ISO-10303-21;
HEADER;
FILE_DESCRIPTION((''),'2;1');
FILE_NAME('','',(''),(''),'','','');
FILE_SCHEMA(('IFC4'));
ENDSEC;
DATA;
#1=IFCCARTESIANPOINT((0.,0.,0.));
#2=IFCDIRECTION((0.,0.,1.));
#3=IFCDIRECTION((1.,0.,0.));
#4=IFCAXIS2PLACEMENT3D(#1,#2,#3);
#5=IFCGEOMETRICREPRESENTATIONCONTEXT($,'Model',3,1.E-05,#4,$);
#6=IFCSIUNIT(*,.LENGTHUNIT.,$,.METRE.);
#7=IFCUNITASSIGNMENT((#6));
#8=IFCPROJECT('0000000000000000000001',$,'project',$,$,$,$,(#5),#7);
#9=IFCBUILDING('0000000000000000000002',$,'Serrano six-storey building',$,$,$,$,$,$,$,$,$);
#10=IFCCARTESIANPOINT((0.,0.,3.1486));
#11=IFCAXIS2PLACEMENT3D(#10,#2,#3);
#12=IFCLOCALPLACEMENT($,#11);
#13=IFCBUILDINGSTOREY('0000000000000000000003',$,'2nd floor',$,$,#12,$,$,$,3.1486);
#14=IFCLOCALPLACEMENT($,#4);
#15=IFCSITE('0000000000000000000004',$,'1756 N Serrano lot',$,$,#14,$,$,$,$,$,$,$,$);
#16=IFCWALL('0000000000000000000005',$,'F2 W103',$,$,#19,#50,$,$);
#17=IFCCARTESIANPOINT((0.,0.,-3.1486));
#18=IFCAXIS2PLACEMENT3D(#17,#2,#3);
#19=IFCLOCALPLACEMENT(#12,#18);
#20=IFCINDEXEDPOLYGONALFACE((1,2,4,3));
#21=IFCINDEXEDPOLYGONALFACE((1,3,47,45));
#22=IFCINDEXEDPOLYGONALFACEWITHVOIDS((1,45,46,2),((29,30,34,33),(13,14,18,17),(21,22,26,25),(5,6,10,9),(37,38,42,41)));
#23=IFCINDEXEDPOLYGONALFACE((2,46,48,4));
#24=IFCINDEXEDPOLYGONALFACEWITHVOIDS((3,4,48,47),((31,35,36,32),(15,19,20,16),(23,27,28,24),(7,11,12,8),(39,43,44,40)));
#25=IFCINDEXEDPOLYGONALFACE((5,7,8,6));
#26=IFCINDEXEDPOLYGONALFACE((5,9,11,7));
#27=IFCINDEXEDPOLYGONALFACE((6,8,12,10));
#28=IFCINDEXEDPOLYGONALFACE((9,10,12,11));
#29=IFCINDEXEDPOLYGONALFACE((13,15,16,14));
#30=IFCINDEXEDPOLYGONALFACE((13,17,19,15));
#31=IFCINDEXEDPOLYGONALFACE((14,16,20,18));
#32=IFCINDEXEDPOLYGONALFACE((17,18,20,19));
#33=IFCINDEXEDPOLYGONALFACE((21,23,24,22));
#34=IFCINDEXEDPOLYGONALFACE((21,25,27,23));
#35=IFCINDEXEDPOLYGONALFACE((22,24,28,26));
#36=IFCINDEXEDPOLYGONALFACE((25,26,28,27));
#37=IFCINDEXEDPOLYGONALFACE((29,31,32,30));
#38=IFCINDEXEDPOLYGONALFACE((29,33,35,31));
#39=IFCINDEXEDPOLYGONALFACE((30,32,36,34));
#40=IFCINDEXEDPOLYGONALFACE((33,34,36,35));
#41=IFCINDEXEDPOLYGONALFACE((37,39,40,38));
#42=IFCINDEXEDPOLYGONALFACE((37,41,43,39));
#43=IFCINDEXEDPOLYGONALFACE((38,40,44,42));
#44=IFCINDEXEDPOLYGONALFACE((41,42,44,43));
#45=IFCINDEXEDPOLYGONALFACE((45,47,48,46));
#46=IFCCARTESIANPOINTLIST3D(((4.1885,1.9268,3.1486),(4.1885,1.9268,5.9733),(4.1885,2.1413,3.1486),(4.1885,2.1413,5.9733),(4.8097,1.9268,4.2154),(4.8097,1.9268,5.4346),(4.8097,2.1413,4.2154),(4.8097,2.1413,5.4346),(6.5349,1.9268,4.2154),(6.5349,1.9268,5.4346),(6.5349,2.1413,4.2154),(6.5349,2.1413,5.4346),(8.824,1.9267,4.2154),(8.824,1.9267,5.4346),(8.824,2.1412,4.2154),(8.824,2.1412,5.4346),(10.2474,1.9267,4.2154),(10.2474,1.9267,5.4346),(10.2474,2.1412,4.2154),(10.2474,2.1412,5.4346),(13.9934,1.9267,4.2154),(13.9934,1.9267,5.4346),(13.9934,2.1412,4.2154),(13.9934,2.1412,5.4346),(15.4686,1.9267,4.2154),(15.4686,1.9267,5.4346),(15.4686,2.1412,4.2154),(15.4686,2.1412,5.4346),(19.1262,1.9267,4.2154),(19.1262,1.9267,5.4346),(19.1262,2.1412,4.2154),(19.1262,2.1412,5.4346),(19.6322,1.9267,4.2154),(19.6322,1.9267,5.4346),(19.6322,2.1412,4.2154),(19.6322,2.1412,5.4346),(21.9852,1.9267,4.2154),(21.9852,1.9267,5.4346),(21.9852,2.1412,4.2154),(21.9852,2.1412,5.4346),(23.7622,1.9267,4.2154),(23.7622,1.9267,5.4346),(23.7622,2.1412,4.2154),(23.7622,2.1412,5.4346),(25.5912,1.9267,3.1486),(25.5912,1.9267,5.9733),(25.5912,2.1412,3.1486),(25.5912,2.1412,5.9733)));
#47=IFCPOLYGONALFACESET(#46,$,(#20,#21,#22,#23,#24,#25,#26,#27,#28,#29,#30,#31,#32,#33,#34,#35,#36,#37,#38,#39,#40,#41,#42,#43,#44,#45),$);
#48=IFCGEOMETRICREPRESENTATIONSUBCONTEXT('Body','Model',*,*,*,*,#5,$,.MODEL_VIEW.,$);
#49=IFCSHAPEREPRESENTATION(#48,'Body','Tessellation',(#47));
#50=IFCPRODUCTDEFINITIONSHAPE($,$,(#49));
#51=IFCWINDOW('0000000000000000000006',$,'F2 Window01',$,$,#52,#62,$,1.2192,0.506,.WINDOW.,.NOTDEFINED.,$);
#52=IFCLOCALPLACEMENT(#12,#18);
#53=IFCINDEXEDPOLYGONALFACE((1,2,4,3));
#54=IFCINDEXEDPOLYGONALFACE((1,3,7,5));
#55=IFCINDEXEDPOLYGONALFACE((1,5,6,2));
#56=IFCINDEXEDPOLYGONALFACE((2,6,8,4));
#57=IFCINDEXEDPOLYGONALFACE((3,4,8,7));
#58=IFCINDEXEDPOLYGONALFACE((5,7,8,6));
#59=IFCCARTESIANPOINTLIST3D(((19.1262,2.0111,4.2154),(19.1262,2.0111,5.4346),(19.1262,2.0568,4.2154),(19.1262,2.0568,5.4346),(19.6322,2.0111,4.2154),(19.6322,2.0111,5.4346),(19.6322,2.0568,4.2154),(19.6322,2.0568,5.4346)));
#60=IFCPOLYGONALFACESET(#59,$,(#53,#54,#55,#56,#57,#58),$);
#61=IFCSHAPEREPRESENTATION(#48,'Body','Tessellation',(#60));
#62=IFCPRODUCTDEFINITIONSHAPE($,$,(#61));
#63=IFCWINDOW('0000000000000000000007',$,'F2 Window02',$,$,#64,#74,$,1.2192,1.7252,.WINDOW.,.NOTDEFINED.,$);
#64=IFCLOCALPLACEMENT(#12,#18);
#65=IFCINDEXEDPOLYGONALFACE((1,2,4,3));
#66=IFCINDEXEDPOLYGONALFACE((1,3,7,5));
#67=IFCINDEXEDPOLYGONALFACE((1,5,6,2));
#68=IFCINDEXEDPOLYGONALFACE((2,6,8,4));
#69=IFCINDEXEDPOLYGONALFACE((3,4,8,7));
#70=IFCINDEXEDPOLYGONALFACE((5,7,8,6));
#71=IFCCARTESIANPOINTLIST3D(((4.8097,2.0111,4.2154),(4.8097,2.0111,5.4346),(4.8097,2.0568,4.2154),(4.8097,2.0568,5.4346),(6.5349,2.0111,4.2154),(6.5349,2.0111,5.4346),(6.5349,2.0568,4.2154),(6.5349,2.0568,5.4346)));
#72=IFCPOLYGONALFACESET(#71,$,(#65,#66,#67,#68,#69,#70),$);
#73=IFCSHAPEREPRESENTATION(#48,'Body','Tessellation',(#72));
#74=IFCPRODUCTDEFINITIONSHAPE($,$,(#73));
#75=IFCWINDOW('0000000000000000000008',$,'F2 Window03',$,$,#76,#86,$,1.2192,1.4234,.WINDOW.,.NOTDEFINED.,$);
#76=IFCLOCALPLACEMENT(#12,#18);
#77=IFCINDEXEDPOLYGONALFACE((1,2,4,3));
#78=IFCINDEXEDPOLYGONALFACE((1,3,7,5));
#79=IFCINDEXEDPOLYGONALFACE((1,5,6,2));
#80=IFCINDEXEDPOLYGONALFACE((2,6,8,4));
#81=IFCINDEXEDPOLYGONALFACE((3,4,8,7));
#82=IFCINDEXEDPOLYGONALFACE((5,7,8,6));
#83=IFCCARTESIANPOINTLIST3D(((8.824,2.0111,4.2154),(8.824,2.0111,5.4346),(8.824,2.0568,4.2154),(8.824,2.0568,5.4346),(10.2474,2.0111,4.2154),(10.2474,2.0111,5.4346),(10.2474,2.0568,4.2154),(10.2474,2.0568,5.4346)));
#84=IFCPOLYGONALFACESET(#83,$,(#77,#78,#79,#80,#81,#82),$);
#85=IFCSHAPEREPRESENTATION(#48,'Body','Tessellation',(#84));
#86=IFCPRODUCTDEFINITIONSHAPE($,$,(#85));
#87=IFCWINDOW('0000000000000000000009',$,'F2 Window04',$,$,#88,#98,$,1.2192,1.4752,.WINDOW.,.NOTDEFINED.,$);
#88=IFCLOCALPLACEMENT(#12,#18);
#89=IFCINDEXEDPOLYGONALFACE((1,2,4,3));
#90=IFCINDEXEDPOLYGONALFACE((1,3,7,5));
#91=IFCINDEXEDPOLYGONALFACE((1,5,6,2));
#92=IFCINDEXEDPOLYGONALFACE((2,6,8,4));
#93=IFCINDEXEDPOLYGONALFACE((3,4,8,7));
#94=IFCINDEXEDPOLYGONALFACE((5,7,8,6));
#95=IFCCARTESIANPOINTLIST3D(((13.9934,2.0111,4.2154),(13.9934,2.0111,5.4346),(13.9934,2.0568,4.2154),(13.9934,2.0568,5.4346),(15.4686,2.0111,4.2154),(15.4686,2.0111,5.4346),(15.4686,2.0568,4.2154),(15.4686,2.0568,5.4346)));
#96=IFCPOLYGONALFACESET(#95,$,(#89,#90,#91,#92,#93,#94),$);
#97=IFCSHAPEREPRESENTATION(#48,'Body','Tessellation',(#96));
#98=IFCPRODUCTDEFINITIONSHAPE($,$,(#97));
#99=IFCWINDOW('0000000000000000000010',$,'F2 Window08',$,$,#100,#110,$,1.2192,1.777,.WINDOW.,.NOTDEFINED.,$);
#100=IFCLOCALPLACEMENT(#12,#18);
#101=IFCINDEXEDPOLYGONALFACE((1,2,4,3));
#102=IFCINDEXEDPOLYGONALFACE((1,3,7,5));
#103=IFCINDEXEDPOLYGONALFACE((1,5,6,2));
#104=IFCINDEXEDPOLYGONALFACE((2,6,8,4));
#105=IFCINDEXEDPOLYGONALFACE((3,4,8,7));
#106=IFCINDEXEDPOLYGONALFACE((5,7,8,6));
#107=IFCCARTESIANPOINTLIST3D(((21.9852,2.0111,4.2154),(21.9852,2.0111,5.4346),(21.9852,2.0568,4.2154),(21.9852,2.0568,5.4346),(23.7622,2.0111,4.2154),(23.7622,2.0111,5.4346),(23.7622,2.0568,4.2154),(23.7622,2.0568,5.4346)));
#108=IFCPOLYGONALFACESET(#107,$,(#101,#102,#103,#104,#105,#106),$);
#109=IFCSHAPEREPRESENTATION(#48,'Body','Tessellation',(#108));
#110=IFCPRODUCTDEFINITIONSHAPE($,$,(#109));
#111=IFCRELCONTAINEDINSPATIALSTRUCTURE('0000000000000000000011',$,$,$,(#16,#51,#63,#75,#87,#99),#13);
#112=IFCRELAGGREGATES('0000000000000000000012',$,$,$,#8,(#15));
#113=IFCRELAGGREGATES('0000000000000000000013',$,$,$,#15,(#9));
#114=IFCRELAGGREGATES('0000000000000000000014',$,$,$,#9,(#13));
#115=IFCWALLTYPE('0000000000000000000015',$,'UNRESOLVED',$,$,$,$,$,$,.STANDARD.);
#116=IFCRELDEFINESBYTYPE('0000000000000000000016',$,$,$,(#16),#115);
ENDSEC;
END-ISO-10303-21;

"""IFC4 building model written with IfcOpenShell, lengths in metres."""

from ifc_helpers import new_model, si_unit, frame, origin_with_axes, place, context, subcontext, project, spatial, polyline, outline, extrude, type_object, element, fill, save


model = new_model("IFC4")

# Units and contexts
model_context = context("Model", 3, precision=1e-05, world=origin_with_axes())
body_context = subcontext(model_context, "Body", "Model", "MODEL_VIEW")
ifc_project = project(units=[si_unit("LENGTHUNIT", "METRE")], contexts=[model_context])

# Site, building, storey
site_placement = place(None, origin_with_axes())
site = spatial("IfcSite", under=ifc_project, at=site_placement, Name="1756 N Serrano lot")
building = spatial("IfcBuilding", under=site, Name="Serrano six-storey building")
storey_placement = place(None, frame((0.0, 0.0, 3.1486), z_axis=(0.0, 0.0, 1.0), x_axis=(1.0, 0.0, 0.0)))
storey = spatial("IfcBuildingStorey", under=building, at=storey_placement, Name="2nd floor", Elevation=3.1486)

# Wall, openings, windows
wall_type = type_object("IfcWallType", Name="UNRESOLVED", PredefinedType="STANDARD")
wall_1_placement = place(storey_placement, frame((0.0, 0.0, -3.1486), z_axis=(0.0, 0.0, 1.0), x_axis=(1.0, 0.0, 0.0)))
wall_1 = element("IfcWall", 1, at=wall_1_placement, inside=storey, type_object=wall_type, Name="F2 W103", context=body_context, shape_type="SweptSolid", body=[
    extrude(outline(polyline([(4.1885, 1.9268), (4.1885, 2.1413), (25.5912, 2.1412), (25.5912, 1.9267), (4.1885, 1.9268)])), frame((0.0, 0.0, 3.1486)), (0.0, 0.0, 1.0), 2.8247),
])
opening_1_placement = place(None, origin_with_axes())
opening_1 = element("IfcOpeningElement", 2, at=opening_1_placement, cuts=wall_1, PredefinedType="OPENING", context=body_context, shape_type="SweptSolid", body=[
    extrude(outline(polyline([(19.6322, 2.1595), (19.6322, 1.9084), (19.1262, 1.9084), (19.1262, 2.1595), (19.6322, 2.1595)])), frame((0.0, 0.0, 4.2154)), (0.0, 0.0, 1.0), 1.2192),
])
opening_2_placement = place(None, origin_with_axes())
opening_2 = element("IfcOpeningElement", 3, at=opening_2_placement, cuts=wall_1, PredefinedType="OPENING", context=body_context, shape_type="SweptSolid", body=[
    extrude(outline(polyline([(6.5349, 2.1595), (6.5349, 1.9084), (4.8097, 1.9084), (4.8097, 2.1595), (6.5349, 2.1595)])), frame((0.0, 0.0, 4.2154)), (0.0, 0.0, 1.0), 1.2192),
])
opening_3_placement = place(None, origin_with_axes())
opening_3 = element("IfcOpeningElement", 4, at=opening_3_placement, cuts=wall_1, PredefinedType="OPENING", context=body_context, shape_type="SweptSolid", body=[
    extrude(outline(polyline([(10.2474, 2.1595), (10.2474, 1.9084), (8.824, 1.9084), (8.824, 2.1595), (10.2474, 2.1595)])), frame((0.0, 0.0, 4.2154)), (0.0, 0.0, 1.0), 1.2192),
])
opening_4_placement = place(None, origin_with_axes())
opening_4 = element("IfcOpeningElement", 5, at=opening_4_placement, cuts=wall_1, PredefinedType="OPENING", context=body_context, shape_type="SweptSolid", body=[
    extrude(outline(polyline([(15.4686, 2.1595), (15.4686, 1.9084), (13.9934, 1.9084), (13.9934, 2.1595), (15.4686, 2.1595)])), frame((0.0, 0.0, 4.2154)), (0.0, 0.0, 1.0), 1.2192),
])
opening_5_placement = place(None, origin_with_axes())
opening_5 = element("IfcOpeningElement", 6, at=opening_5_placement, cuts=wall_1, PredefinedType="OPENING", context=body_context, shape_type="SweptSolid", body=[
    extrude(outline(polyline([(23.7622, 2.1595), (23.7622, 1.9084), (21.9852, 1.9084), (21.9852, 2.1595), (23.7622, 2.1595)])), frame((0.0, 0.0, 4.2154)), (0.0, 0.0, 1.0), 1.2192),
])
window_1_placement = place(storey_placement, frame((0.0, 0.0, -3.1486), z_axis=(0.0, 0.0, 1.0), x_axis=(1.0, 0.0, 0.0)))
window_1 = element("IfcWindow", 7, at=window_1_placement, inside=storey, Name="F2 Window01", OverallHeight=1.2192, OverallWidth=0.506, PartitioningType="NOTDEFINED", PredefinedType="WINDOW", context=body_context, shape_type="SweptSolid", body=[
    extrude(outline(polyline([(19.6322, 2.0568), (19.6322, 2.0111), (19.1262, 2.0111), (19.1262, 2.0568), (19.6322, 2.0568)])), frame((0.0, 0.0, 4.2154)), (0.0, 0.0, 1.0), 1.2192),
])
fill(opening_1, window_1)
window_2_placement = place(storey_placement, frame((0.0, 0.0, -3.1486), z_axis=(0.0, 0.0, 1.0), x_axis=(1.0, 0.0, 0.0)))
window_2 = element("IfcWindow", 8, at=window_2_placement, inside=storey, Name="F2 Window02", OverallHeight=1.2192, OverallWidth=1.7252, PartitioningType="NOTDEFINED", PredefinedType="WINDOW", context=body_context, shape_type="SweptSolid", body=[
    extrude(outline(polyline([(6.5349, 2.0568), (6.5349, 2.0111), (4.8097, 2.0111), (4.8097, 2.0568), (6.5349, 2.0568)])), frame((0.0, 0.0, 4.2154)), (0.0, 0.0, 1.0), 1.2192),
])
fill(opening_2, window_2)
window_3_placement = place(storey_placement, frame((0.0, 0.0, -3.1486), z_axis=(0.0, 0.0, 1.0), x_axis=(1.0, 0.0, 0.0)))
window_3 = element("IfcWindow", 9, at=window_3_placement, inside=storey, Name="F2 Window03", OverallHeight=1.2192, OverallWidth=1.4234, PartitioningType="NOTDEFINED", PredefinedType="WINDOW", context=body_context, shape_type="SweptSolid", body=[
    extrude(outline(polyline([(10.2474, 2.0568), (10.2474, 2.0111), (8.824, 2.0111), (8.824, 2.0568), (10.2474, 2.0568)])), frame((0.0, 0.0, 4.2154)), (0.0, 0.0, 1.0), 1.2192),
])
fill(opening_3, window_3)
window_4_placement = place(storey_placement, frame((0.0, 0.0, -3.1486), z_axis=(0.0, 0.0, 1.0), x_axis=(1.0, 0.0, 0.0)))
window_4 = element("IfcWindow", 10, at=window_4_placement, inside=storey, Name="F2 Window04", OverallHeight=1.2192, OverallWidth=1.4752, PartitioningType="NOTDEFINED", PredefinedType="WINDOW", context=body_context, shape_type="SweptSolid", body=[
    extrude(outline(polyline([(15.4686, 2.0568), (15.4686, 2.0111), (13.9934, 2.0111), (13.9934, 2.0568), (15.4686, 2.0568)])), frame((0.0, 0.0, 4.2154)), (0.0, 0.0, 1.0), 1.2192),
])
fill(opening_4, window_4)
window_5_placement = place(storey_placement, frame((0.0, 0.0, -3.1486), z_axis=(0.0, 0.0, 1.0), x_axis=(1.0, 0.0, 0.0)))
window_5 = element("IfcWindow", 11, at=window_5_placement, inside=storey, Name="F2 Window08", OverallHeight=1.2192, OverallWidth=1.777, PartitioningType="NOTDEFINED", PredefinedType="WINDOW", context=body_context, shape_type="SweptSolid", body=[
    extrude(outline(polyline([(23.7622, 2.0568), (23.7622, 2.0111), (21.9852, 2.0111), (21.9852, 2.0568), (23.7622, 2.0568)])), frame((0.0, 0.0, 4.2154)), (0.0, 0.0, 1.0), 1.2192),
])
fill(opening_5, window_5)

save(model, "model.ifc")
